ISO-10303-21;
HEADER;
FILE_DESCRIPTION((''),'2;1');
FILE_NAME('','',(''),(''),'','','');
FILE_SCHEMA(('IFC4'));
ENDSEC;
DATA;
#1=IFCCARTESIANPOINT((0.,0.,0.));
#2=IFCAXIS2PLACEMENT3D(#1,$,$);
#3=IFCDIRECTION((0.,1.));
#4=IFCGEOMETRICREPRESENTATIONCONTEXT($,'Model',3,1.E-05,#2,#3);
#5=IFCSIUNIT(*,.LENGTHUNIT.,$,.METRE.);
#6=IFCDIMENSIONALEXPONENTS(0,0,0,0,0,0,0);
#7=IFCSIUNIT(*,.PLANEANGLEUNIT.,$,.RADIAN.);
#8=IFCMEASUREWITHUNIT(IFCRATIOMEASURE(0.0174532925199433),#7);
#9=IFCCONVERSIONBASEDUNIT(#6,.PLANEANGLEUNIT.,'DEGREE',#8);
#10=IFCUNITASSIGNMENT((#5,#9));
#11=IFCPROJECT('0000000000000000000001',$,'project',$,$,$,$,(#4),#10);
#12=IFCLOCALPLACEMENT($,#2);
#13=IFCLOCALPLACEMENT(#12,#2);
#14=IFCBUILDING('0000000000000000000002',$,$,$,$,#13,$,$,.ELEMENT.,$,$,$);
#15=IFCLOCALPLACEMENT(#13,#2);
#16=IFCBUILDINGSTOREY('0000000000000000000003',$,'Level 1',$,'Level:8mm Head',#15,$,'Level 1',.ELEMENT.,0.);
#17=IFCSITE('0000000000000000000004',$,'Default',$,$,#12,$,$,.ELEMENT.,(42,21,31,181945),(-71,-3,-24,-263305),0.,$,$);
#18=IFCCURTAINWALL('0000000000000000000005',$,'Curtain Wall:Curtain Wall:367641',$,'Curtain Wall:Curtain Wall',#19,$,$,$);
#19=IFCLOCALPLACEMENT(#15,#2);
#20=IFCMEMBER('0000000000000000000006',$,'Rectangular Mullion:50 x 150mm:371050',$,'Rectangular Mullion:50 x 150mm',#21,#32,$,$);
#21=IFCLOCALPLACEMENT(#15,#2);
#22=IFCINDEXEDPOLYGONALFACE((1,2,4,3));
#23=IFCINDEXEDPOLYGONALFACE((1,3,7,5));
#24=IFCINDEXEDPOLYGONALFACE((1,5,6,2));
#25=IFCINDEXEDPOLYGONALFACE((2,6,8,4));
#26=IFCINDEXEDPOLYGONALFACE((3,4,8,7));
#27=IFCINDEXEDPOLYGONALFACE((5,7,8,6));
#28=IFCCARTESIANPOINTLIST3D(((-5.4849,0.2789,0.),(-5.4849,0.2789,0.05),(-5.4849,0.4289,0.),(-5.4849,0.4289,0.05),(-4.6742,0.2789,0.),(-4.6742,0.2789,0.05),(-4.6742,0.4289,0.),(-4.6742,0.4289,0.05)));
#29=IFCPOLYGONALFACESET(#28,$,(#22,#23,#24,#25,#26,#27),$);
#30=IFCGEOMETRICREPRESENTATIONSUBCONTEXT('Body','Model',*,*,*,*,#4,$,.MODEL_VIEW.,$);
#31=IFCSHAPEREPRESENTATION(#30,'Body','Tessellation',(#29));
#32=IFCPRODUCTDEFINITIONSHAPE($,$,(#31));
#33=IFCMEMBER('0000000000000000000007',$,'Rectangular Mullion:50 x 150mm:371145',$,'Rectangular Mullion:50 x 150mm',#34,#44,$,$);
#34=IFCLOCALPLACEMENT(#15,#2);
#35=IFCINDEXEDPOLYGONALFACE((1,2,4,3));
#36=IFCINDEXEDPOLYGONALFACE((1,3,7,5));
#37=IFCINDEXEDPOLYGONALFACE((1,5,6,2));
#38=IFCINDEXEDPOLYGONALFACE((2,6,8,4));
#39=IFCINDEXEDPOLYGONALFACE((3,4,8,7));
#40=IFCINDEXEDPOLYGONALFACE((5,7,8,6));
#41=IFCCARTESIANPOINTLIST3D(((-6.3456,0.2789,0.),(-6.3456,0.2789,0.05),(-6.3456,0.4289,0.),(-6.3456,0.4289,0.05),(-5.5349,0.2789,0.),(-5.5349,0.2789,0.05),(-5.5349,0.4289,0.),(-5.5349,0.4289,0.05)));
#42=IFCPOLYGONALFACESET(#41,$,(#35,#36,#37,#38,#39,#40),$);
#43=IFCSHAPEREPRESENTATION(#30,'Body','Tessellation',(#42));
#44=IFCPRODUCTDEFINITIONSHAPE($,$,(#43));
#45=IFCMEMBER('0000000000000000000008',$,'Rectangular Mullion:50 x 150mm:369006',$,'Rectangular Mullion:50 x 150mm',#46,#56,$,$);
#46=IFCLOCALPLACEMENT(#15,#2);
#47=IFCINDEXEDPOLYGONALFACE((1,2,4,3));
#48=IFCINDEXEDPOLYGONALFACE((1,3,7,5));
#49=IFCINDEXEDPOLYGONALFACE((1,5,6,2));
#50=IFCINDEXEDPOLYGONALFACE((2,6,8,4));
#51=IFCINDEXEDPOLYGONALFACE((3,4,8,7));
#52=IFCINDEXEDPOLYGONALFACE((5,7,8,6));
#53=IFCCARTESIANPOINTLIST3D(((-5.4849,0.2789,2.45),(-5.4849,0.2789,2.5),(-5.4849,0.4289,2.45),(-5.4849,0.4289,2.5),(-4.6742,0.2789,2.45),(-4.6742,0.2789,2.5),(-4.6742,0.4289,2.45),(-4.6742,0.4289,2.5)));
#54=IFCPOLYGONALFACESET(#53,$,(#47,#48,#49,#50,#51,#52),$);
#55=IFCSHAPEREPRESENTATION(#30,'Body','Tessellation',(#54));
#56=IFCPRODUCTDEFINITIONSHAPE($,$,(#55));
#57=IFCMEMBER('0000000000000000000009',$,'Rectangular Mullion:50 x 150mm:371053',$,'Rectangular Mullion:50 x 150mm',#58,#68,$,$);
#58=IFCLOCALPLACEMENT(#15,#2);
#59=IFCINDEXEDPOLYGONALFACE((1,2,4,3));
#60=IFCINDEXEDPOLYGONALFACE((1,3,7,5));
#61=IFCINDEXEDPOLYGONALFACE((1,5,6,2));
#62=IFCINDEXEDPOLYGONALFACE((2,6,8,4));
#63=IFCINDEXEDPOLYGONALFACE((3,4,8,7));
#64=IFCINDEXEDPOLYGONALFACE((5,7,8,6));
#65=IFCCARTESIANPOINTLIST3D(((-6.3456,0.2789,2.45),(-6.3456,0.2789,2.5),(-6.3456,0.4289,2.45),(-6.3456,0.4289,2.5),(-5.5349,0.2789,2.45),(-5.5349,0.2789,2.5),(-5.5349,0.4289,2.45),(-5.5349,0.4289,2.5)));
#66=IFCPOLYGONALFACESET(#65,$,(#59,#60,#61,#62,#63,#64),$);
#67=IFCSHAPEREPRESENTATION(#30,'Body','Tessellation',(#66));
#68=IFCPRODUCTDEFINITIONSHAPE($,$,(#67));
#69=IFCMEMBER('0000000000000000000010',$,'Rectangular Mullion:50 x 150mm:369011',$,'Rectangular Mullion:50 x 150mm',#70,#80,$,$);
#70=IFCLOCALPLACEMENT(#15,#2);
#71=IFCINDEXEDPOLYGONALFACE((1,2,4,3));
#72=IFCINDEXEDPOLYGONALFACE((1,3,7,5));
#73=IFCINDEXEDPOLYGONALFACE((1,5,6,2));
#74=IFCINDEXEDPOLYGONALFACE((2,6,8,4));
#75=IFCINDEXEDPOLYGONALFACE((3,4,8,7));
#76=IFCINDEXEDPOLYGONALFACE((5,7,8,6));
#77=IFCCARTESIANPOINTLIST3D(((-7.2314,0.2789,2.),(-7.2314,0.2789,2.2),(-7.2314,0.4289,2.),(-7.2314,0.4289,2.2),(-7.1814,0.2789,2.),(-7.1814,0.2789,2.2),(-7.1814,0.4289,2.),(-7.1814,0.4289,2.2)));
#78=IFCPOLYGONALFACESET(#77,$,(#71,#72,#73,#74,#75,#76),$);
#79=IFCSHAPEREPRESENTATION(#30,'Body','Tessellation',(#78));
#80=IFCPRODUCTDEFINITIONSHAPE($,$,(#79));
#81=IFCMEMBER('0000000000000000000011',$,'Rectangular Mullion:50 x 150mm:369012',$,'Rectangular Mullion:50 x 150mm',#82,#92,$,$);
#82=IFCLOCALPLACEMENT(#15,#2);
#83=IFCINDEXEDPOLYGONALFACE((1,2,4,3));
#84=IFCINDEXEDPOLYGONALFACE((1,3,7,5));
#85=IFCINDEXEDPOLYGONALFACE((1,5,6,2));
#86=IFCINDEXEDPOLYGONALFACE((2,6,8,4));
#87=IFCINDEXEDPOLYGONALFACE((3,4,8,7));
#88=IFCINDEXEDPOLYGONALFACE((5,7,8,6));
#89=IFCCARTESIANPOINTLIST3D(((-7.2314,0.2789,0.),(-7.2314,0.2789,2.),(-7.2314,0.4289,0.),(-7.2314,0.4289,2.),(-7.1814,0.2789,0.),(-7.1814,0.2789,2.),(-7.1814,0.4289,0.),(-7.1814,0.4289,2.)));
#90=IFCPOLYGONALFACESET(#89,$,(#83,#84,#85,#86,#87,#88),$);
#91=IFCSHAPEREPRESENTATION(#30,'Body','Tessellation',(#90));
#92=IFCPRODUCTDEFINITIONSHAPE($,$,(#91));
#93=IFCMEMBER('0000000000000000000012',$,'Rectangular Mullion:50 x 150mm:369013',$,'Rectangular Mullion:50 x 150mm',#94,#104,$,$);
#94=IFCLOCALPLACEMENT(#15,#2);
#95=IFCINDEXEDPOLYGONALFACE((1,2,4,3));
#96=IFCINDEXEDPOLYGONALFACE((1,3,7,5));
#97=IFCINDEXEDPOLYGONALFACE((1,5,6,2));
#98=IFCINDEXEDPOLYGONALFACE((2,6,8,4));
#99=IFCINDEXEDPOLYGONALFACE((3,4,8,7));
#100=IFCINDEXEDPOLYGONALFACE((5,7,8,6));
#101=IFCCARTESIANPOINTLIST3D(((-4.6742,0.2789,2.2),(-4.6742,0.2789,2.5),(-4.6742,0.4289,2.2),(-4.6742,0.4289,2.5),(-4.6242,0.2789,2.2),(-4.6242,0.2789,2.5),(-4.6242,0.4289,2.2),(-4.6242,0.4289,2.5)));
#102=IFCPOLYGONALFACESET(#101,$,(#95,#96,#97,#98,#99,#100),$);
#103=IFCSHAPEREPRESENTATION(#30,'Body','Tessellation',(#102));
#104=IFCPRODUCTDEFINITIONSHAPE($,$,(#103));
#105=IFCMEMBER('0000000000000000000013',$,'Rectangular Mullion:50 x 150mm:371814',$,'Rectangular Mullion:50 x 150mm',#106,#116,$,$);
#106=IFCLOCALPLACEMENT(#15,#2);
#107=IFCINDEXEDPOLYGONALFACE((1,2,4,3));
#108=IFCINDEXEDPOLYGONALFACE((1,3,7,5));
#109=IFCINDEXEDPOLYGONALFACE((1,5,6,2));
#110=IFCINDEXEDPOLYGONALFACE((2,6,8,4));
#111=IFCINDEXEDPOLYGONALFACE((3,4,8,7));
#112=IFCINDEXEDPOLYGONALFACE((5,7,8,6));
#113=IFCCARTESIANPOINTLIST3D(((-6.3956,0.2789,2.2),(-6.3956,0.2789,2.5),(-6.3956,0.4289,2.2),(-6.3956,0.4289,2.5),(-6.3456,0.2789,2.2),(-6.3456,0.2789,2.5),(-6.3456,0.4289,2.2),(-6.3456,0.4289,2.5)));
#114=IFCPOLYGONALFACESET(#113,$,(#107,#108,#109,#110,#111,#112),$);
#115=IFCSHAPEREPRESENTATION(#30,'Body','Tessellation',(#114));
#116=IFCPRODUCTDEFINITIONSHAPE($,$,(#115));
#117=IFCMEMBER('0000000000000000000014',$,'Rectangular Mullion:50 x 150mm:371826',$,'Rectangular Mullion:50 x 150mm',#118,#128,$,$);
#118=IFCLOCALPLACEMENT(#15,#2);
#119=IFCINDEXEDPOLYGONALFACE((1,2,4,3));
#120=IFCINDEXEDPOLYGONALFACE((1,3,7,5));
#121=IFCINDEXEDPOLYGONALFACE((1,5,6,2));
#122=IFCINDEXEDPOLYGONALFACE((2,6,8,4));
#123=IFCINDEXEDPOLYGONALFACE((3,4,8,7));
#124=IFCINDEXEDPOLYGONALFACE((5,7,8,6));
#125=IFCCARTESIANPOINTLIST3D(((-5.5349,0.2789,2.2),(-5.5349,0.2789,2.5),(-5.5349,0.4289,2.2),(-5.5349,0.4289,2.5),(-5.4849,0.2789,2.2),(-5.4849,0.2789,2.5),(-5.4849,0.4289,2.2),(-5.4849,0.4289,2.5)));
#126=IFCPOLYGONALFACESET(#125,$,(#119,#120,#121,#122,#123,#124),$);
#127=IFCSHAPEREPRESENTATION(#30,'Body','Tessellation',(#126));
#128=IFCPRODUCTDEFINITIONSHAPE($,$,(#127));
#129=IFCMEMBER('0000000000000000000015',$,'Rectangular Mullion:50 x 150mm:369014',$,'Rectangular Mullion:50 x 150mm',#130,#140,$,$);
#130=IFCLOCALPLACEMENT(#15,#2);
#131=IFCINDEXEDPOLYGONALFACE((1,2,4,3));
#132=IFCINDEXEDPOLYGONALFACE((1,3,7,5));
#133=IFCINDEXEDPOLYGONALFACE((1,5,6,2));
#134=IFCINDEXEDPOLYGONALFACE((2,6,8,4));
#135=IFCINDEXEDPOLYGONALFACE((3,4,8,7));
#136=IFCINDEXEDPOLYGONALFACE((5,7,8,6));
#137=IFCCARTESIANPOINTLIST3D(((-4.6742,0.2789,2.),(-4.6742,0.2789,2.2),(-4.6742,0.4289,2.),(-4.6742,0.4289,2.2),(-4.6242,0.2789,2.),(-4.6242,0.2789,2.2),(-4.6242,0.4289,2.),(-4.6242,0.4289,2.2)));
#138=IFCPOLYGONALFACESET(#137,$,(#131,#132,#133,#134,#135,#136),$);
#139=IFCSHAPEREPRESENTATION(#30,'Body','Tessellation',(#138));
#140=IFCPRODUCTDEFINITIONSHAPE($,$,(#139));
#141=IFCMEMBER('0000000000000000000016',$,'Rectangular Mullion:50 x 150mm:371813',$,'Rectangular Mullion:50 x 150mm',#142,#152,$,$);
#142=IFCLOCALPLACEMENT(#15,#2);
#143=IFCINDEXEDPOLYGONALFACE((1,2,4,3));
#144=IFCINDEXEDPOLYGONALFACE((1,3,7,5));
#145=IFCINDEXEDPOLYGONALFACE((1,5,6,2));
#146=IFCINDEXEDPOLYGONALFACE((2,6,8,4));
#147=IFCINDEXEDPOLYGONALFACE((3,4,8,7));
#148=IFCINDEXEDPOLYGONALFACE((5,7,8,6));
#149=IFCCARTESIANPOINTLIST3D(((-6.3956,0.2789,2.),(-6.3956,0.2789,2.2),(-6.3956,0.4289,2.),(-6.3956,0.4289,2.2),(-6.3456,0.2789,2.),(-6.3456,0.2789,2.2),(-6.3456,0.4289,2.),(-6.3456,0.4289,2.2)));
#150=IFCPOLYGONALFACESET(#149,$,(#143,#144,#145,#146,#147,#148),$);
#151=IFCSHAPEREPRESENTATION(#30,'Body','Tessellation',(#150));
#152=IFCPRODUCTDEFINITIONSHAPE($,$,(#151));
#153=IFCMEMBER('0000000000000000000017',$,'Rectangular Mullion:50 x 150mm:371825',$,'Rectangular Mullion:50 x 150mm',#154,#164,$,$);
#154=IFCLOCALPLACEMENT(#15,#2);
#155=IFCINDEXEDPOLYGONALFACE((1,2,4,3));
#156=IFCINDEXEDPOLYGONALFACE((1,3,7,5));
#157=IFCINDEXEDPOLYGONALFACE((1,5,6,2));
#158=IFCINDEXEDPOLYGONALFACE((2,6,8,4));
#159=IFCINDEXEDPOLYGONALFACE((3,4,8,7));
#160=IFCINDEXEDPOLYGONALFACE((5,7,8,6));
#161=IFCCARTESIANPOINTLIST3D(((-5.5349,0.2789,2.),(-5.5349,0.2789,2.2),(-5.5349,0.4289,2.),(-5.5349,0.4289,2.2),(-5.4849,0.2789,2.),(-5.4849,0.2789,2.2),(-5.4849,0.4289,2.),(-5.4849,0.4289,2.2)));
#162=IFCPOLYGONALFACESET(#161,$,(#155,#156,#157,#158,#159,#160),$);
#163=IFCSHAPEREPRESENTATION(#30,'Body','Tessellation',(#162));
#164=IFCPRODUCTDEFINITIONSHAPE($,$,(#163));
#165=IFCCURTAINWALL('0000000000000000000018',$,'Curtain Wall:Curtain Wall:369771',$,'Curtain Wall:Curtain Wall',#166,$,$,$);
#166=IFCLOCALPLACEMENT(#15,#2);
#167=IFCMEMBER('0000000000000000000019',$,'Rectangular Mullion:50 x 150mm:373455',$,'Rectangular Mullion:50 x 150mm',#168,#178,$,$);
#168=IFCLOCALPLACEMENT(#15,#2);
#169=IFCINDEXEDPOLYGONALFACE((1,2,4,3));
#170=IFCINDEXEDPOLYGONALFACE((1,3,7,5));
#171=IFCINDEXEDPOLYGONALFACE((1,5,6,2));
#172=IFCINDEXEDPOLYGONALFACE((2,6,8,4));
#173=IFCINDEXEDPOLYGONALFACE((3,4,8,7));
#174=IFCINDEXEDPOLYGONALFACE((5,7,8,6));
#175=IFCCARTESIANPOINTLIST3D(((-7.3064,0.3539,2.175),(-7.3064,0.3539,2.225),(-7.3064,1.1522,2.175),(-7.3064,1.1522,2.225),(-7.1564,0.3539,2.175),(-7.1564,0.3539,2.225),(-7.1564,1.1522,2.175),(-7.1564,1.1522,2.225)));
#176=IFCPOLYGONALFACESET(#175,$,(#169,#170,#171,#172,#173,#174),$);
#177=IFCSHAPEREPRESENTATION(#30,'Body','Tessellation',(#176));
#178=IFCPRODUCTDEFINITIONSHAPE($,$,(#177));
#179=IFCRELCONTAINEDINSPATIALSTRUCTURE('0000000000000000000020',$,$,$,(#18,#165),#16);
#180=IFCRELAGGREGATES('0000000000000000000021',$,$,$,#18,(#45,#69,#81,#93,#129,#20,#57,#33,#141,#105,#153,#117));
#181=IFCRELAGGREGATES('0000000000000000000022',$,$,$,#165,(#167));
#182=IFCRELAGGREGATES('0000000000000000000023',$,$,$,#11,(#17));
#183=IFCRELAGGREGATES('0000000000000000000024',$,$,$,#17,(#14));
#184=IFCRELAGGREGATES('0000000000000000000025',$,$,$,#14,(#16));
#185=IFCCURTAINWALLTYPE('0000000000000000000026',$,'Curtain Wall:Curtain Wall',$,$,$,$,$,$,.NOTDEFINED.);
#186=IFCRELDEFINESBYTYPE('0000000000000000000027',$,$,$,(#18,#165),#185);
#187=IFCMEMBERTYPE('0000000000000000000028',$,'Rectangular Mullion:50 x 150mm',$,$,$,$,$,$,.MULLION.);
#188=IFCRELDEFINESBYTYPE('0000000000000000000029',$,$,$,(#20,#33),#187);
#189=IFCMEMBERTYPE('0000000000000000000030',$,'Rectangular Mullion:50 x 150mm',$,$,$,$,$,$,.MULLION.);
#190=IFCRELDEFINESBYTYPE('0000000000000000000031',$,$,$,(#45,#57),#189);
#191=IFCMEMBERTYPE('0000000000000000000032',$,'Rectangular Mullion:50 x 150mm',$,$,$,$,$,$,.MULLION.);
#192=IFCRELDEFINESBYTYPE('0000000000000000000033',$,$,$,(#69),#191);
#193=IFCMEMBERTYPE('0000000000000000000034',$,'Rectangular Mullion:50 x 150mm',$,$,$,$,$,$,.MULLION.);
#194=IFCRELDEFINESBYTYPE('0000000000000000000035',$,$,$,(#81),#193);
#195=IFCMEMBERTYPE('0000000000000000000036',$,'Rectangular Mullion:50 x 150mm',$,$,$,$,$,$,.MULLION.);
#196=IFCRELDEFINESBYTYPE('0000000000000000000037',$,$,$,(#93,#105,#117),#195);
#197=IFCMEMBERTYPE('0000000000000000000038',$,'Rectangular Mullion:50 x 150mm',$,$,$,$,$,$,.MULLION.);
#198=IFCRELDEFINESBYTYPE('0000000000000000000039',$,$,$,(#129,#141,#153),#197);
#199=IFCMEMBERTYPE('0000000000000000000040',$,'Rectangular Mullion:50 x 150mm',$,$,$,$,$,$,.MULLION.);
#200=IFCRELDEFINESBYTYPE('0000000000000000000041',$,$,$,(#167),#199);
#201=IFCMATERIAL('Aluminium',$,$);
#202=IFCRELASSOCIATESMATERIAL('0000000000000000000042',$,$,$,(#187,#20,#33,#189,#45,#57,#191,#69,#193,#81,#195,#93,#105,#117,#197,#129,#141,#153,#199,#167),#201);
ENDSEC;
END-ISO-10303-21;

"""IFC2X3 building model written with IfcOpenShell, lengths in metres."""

from ifc_helpers import new_model, entity, si_unit, converted_unit, direction, frame, origin, origin_2d_with_axis, place, context, subcontext, project, spatial, rectangle, extrude, source, transform, mapped, material, type_object, type_shapes, element, aggregate, save


model = new_model("IFC2X3")

# Units and contexts
model_context = context("Model", 3, precision=1e-05, world=origin(), true_north=direction((0.0, 1.0)))
body_context = subcontext(model_context, "Body", "Model", "MODEL_VIEW")
ifc_project = project(units=[si_unit("LENGTHUNIT", "METRE"), converted_unit("PLANEANGLEUNIT", "DEGREE", entity("IfcRatioMeasure", 0.0174532925199433), si_unit("PLANEANGLEUNIT", "RADIAN"), dimensions=[0, 0, 0, 0, 0, 0, 0])], contexts=[model_context])

# Site, building, storey
site_placement = place(None, origin())
site = spatial("IfcSite", under=ifc_project, at=site_placement, Name="Default", CompositionType="ELEMENT", RefLatitude=(42, 21, 31, 181945), RefLongitude=(-71, -3, -24, -263305), RefElevation=0.0)
building_placement = place(site_placement, origin())
building = spatial("IfcBuilding", under=site, at=building_placement, CompositionType="ELEMENT")
storey_placement = place(building_placement, origin())
storey = spatial("IfcBuildingStorey", under=building, at=storey_placement, Name="Level 1", ObjectType="Level:8mm Head", LongName="Level 1", CompositionType="ELEMENT", Elevation=0.0)

# Curtain walls, members
curtain_wall_type = type_object("IfcCurtainWallType", Name="Curtain Wall:Curtain Wall", PredefinedType="NOTDEFINED")
curtain_wall_1_placement = place(storey_placement, origin())
curtain_wall_1 = element("IfcCurtainWall", 1, at=curtain_wall_1_placement, inside=storey, type_object=curtain_wall_type, Name="Curtain Wall:Curtain Wall:367641", ObjectType="Curtain Wall:Curtain Wall")
ifc_material_1 = material(Name="Aluminium")
member_type_1 = type_object("IfcMemberType", Name="Rectangular Mullion:50 x 150mm", PredefinedType="MULLION", material=ifc_material_1)
shared_shape_1 = source(origin(), body_context, "Body", "SweptSolid", [
    extrude(rectangle(XDim=0.15, YDim=0.05, at=origin_2d_with_axis()), frame((-0.025, 0.0, -0.8107), z_axis=(0.0, 0.0, 1.0), x_axis=(0.0, -1.0, 0.0)), (0.0, 0.0, 1.0), 0.8107),
])
type_shapes(member_type_1, [shared_shape_1])
member_1_placement = place(storey_placement, frame((-5.4849, 0.3539, 0.0), z_axis=(-1.0, 0.0, 0.0), x_axis=(0.0, 0.0, -1.0)))
member_1 = element("IfcMember", 2, at=member_1_placement, type_object=member_type_1, material=ifc_material_1, Name="Rectangular Mullion:50 x 150mm:371050", ObjectType="Rectangular Mullion:50 x 150mm", context=body_context, shape_type="MappedRepresentation", body=[
    mapped(shared_shape_1, transform((0.0, 0.0, 0.0), scale=1.0)),
])
member_2_placement = place(storey_placement, frame((-6.3456, 0.3539, 0.0), z_axis=(-1.0, 0.0, 0.0), x_axis=(0.0, 0.0, -1.0)))
member_2 = element("IfcMember", 3, at=member_2_placement, type_object=member_type_1, material=ifc_material_1, Name="Rectangular Mullion:50 x 150mm:371145", ObjectType="Rectangular Mullion:50 x 150mm", context=body_context, shape_type="MappedRepresentation", body=[
    mapped(shared_shape_1, transform((0.0, 0.0, 0.0), scale=1.0)),
])
member_type_2 = type_object("IfcMemberType", Name="Rectangular Mullion:50 x 150mm", PredefinedType="MULLION", material=ifc_material_1)
shared_shape_2 = source(origin(), body_context, "Body", "SweptSolid", [
    extrude(rectangle(XDim=0.15, YDim=0.05, at=origin_2d_with_axis()), frame((-0.025, 0.0, -0.8107), z_axis=(0.0, 0.0, 1.0), x_axis=(0.0, -1.0, 0.0)), (0.0, 0.0, 1.0), 0.8107),
])
type_shapes(member_type_2, [shared_shape_2])
member_3_placement = place(storey_placement, frame((-4.6742, 0.3539, 2.5), z_axis=(1.0, 0.0, 0.0), x_axis=(0.0, 0.0, 1.0)))
member_3 = element("IfcMember", 4, at=member_3_placement, type_object=member_type_2, material=ifc_material_1, Name="Rectangular Mullion:50 x 150mm:369006", ObjectType="Rectangular Mullion:50 x 150mm", context=body_context, shape_type="MappedRepresentation", body=[
    mapped(shared_shape_2, transform((0.0, 0.0, 0.0), scale=1.0)),
])
member_4_placement = place(storey_placement, frame((-5.5349, 0.3539, 2.5), z_axis=(1.0, 0.0, 0.0), x_axis=(0.0, 0.0, 1.0)))
member_4 = element("IfcMember", 5, at=member_4_placement, type_object=member_type_2, material=ifc_material_1, Name="Rectangular Mullion:50 x 150mm:371053", ObjectType="Rectangular Mullion:50 x 150mm", context=body_context, shape_type="MappedRepresentation", body=[
    mapped(shared_shape_2, transform((0.0, 0.0, 0.0), scale=1.0)),
])
member_type_3 = type_object("IfcMemberType", Name="Rectangular Mullion:50 x 150mm", PredefinedType="MULLION", material=ifc_material_1)
shared_shape_3 = source(origin(), body_context, "Body", "SweptSolid", [
    extrude(rectangle(XDim=0.15, YDim=0.05, at=origin_2d_with_axis()), frame((-0.025, 0.0, -0.2), z_axis=(0.0, 0.0, 1.0), x_axis=(0.0, -1.0, 0.0)), (0.0, 0.0, 1.0), 0.2),
])
type_shapes(member_type_3, [shared_shape_3])
member_5_placement = place(storey_placement, frame((-7.2314, 0.3539, 2.2), z_axis=(0.0, 0.0, 1.0), x_axis=(-1.0, 0.0, 0.0)))
member_5 = element("IfcMember", 6, at=member_5_placement, type_object=member_type_3, material=ifc_material_1, Name="Rectangular Mullion:50 x 150mm:369011", ObjectType="Rectangular Mullion:50 x 150mm", context=body_context, shape_type="MappedRepresentation", body=[
    mapped(shared_shape_3, transform((0.0, 0.0, 0.0), scale=1.0)),
])
member_type_4 = type_object("IfcMemberType", Name="Rectangular Mullion:50 x 150mm", PredefinedType="MULLION", material=ifc_material_1)
shared_shape_4 = source(origin(), body_context, "Body", "SweptSolid", [
    extrude(rectangle(XDim=0.15, YDim=0.05, at=origin_2d_with_axis()), frame((-0.025, 0.0, -2.0), z_axis=(0.0, 0.0, 1.0), x_axis=(0.0, -1.0, 0.0)), (0.0, 0.0, 1.0), 2.0),
])
type_shapes(member_type_4, [shared_shape_4])
member_6_placement = place(storey_placement, frame((-7.2314, 0.3539, 2.0), z_axis=(0.0, 0.0, 1.0), x_axis=(-1.0, 0.0, 0.0)))
member_6 = element("IfcMember", 7, at=member_6_placement, type_object=member_type_4, material=ifc_material_1, Name="Rectangular Mullion:50 x 150mm:369012", ObjectType="Rectangular Mullion:50 x 150mm", context=body_context, shape_type="MappedRepresentation", body=[
    mapped(shared_shape_4, transform((0.0, 0.0, 0.0), scale=1.0)),
])
member_type_5 = type_object("IfcMemberType", Name="Rectangular Mullion:50 x 150mm", PredefinedType="MULLION", material=ifc_material_1)
shared_shape_5 = source(origin(), body_context, "Body", "SweptSolid", [
    extrude(rectangle(XDim=0.15, YDim=0.05, at=origin_2d_with_axis()), frame((0.0, 0.0, -0.3), z_axis=(0.0, 0.0, 1.0), x_axis=(0.0, -1.0, 0.0)), (0.0, 0.0, 1.0), 0.3),
])
type_shapes(member_type_5, [shared_shape_5])
member_7_placement = place(storey_placement, frame((-4.6492, 0.3539, 2.2), z_axis=(0.0, 0.0, -1.0), x_axis=(1.0, 0.0, 0.0)))
member_7 = element("IfcMember", 8, at=member_7_placement, type_object=member_type_5, material=ifc_material_1, Name="Rectangular Mullion:50 x 150mm:369013", ObjectType="Rectangular Mullion:50 x 150mm", context=body_context, shape_type="MappedRepresentation", body=[
    mapped(shared_shape_5, transform((0.0, 0.0, 0.0), scale=1.0)),
])
member_8_placement = place(storey_placement, frame((-6.3706, 0.3539, 2.2), z_axis=(0.0, 0.0, -1.0), x_axis=(1.0, 0.0, 0.0)))
member_8 = element("IfcMember", 9, at=member_8_placement, type_object=member_type_5, material=ifc_material_1, Name="Rectangular Mullion:50 x 150mm:371814", ObjectType="Rectangular Mullion:50 x 150mm", context=body_context, shape_type="MappedRepresentation", body=[
    mapped(shared_shape_5, transform((0.0, 0.0, 0.0), scale=1.0)),
])
member_9_placement = place(storey_placement, frame((-5.5099, 0.3539, 2.2), z_axis=(0.0, 0.0, -1.0), x_axis=(1.0, 0.0, 0.0)))
member_9 = element("IfcMember", 10, at=member_9_placement, type_object=member_type_5, material=ifc_material_1, Name="Rectangular Mullion:50 x 150mm:371826", ObjectType="Rectangular Mullion:50 x 150mm", context=body_context, shape_type="MappedRepresentation", body=[
    mapped(shared_shape_5, transform((0.0, 0.0, 0.0), scale=1.0)),
])
member_type_6 = type_object("IfcMemberType", Name="Rectangular Mullion:50 x 150mm", PredefinedType="MULLION", material=ifc_material_1)
shared_shape_6 = source(origin(), body_context, "Body", "SweptSolid", [
    extrude(rectangle(XDim=0.15, YDim=0.05, at=origin_2d_with_axis()), frame((0.0, 0.0, -0.2), z_axis=(0.0, 0.0, 1.0), x_axis=(0.0, -1.0, 0.0)), (0.0, 0.0, 1.0), 0.2),
])
type_shapes(member_type_6, [shared_shape_6])
member_10_placement = place(storey_placement, frame((-4.6492, 0.3539, 2.0), z_axis=(0.0, 0.0, -1.0), x_axis=(1.0, 0.0, 0.0)))
member_10 = element("IfcMember", 11, at=member_10_placement, type_object=member_type_6, material=ifc_material_1, Name="Rectangular Mullion:50 x 150mm:369014", ObjectType="Rectangular Mullion:50 x 150mm", context=body_context, shape_type="MappedRepresentation", body=[
    mapped(shared_shape_6, transform((0.0, 0.0, 0.0), scale=1.0)),
])
member_11_placement = place(storey_placement, frame((-6.3706, 0.3539, 2.0), z_axis=(0.0, 0.0, -1.0), x_axis=(1.0, 0.0, 0.0)))
member_11 = element("IfcMember", 12, at=member_11_placement, type_object=member_type_6, material=ifc_material_1, Name="Rectangular Mullion:50 x 150mm:371813", ObjectType="Rectangular Mullion:50 x 150mm", context=body_context, shape_type="MappedRepresentation", body=[
    mapped(shared_shape_6, transform((0.0, 0.0, 0.0), scale=1.0)),
])
member_12_placement = place(storey_placement, frame((-5.5099, 0.3539, 2.0), z_axis=(0.0, 0.0, -1.0), x_axis=(1.0, 0.0, 0.0)))
member_12 = element("IfcMember", 13, at=member_12_placement, type_object=member_type_6, material=ifc_material_1, Name="Rectangular Mullion:50 x 150mm:371825", ObjectType="Rectangular Mullion:50 x 150mm", context=body_context, shape_type="MappedRepresentation", body=[
    mapped(shared_shape_6, transform((0.0, 0.0, 0.0), scale=1.0)),
])
curtain_wall_2_placement = place(storey_placement, origin())
curtain_wall_2 = element("IfcCurtainWall", 14, at=curtain_wall_2_placement, inside=storey, type_object=curtain_wall_type, Name="Curtain Wall:Curtain Wall:369771", ObjectType="Curtain Wall:Curtain Wall")
member_type_7 = type_object("IfcMemberType", Name="Rectangular Mullion:50 x 150mm", PredefinedType="MULLION", material=ifc_material_1)
shared_shape_7 = source(origin(), body_context, "Body", "SweptSolid", [
    extrude(rectangle(XDim=0.15, YDim=0.05, at=origin_2d_with_axis()), frame((0.0, 0.0, -0.7983), z_axis=(0.0, 0.0, 1.0), x_axis=(0.0, -1.0, 0.0)), (0.0, 0.0, 1.0), 0.7983),
])
type_shapes(member_type_7, [shared_shape_7])
member_13_placement = place(storey_placement, frame((-7.2314, 0.3539, 2.2), z_axis=(0.0, -1.0, 0.0), x_axis=(0.0, 0.0, 1.0)))
member_13 = element("IfcMember", 15, at=member_13_placement, type_object=member_type_7, material=ifc_material_1, Name="Rectangular Mullion:50 x 150mm:373455", ObjectType="Rectangular Mullion:50 x 150mm", context=body_context, shape_type="MappedRepresentation", body=[
    mapped(shared_shape_7, transform((0.0, 0.0, 0.0), scale=1.0)),
])

aggregate(curtain_wall_1, [member_3, member_5, member_6, member_7, member_10, member_1, member_4, member_2, member_11, member_8, member_12, member_9])
aggregate(curtain_wall_2, [member_13])

save(model, "model.ifc")
